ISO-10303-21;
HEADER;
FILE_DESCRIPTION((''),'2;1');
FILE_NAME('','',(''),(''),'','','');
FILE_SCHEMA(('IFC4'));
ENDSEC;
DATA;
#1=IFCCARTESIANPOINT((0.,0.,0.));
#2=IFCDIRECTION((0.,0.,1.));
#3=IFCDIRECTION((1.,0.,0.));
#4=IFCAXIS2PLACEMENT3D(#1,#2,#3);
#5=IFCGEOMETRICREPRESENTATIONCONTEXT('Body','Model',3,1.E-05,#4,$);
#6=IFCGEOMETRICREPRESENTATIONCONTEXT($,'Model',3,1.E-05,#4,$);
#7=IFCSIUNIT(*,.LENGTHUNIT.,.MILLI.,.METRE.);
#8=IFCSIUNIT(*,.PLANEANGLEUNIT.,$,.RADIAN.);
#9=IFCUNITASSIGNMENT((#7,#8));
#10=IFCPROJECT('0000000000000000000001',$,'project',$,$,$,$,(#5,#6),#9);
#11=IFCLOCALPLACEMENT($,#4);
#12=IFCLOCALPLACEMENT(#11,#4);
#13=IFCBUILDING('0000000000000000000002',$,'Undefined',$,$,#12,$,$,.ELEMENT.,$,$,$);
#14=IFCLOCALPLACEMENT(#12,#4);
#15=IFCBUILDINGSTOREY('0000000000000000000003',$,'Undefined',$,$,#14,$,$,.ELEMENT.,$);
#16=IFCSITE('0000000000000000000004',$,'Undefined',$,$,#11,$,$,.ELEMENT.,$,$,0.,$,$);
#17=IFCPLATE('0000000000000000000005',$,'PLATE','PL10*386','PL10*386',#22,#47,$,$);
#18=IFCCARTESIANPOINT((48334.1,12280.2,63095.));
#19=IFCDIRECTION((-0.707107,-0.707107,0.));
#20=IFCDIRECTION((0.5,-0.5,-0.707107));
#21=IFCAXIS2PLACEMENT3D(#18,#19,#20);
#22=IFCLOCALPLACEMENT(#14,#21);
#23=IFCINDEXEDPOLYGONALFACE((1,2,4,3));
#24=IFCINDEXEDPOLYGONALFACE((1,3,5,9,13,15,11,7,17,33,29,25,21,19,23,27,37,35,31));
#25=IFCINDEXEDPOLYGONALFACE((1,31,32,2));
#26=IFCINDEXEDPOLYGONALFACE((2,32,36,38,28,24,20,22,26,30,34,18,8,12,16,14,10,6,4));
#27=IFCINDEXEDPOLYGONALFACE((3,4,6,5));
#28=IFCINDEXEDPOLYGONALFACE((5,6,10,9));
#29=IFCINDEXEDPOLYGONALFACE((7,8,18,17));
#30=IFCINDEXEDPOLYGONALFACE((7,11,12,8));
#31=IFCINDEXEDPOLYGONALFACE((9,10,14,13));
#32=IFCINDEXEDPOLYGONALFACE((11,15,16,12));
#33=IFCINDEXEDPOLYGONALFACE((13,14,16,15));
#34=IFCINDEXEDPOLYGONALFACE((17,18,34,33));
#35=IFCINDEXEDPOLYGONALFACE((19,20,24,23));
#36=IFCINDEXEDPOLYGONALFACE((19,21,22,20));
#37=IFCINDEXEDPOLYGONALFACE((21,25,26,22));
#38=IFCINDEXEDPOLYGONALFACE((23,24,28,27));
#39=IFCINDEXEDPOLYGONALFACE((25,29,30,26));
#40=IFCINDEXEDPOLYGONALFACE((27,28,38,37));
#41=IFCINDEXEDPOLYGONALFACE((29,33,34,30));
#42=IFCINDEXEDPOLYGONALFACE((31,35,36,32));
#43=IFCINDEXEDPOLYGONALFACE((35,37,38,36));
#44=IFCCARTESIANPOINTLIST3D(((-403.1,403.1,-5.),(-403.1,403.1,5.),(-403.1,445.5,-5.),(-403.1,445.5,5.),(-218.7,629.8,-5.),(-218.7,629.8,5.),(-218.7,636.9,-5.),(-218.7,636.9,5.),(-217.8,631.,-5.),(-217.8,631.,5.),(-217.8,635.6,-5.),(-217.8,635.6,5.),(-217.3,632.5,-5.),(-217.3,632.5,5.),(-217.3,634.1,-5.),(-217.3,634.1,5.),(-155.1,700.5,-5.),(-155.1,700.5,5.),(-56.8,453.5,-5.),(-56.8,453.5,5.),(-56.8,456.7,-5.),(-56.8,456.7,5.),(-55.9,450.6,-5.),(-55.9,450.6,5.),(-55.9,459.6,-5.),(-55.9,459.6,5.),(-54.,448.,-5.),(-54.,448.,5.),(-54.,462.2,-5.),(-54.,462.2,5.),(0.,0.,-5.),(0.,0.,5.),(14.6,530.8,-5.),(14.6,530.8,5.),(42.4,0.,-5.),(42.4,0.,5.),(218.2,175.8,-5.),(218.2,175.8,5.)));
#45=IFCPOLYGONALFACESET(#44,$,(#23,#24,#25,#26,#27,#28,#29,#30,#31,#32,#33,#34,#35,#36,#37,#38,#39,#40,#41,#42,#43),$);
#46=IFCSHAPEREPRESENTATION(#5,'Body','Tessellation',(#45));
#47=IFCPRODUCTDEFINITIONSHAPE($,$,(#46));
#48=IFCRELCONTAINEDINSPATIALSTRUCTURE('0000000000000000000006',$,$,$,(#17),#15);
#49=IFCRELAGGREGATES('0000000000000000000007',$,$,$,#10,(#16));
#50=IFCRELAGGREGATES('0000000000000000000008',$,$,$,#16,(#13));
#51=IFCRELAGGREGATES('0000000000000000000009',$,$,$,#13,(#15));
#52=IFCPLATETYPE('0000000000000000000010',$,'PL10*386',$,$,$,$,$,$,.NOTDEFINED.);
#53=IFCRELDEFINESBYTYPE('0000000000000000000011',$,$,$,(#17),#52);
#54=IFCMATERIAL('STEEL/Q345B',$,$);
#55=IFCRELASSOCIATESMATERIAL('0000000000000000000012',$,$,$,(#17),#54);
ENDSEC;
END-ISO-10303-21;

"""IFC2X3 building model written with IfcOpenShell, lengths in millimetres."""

from ifc_helpers import new_model, si_unit, frame, origin_with_axes, place, context, project, spatial, polyline, outline, extrude, material, type_object, element, save


model = new_model("IFC2X3")

# Units and contexts
model_context_1 = context("Model", 3, precision=1e-05, world=origin_with_axes(), identifier="Body")
model_context_2 = context("Model", 3, precision=1e-05, world=origin_with_axes())
ifc_project = project(units=[si_unit("LENGTHUNIT", "METRE", prefix="MILLI"), si_unit("PLANEANGLEUNIT", "RADIAN")], contexts=[model_context_1, model_context_2])

# Site, building, storey
site_placement = place(None, origin_with_axes())
site = spatial("IfcSite", under=ifc_project, at=site_placement, Name="Undefined", CompositionType="ELEMENT", RefElevation=0.0)
building_placement = place(site_placement, origin_with_axes())
building = spatial("IfcBuilding", under=site, at=building_placement, Name="Undefined", CompositionType="ELEMENT")
storey_placement = place(building_placement, origin_with_axes())
storey = spatial("IfcBuildingStorey", under=building, at=storey_placement, Name="Undefined", CompositionType="ELEMENT")

# Shared definitions
ifc_material_1 = material(Name="STEEL/Q345B")

# Plate
plate_type_1 = type_object("IfcPlateType", Name="PL10*386", PredefinedType="NOTDEFINED")
plate_1_placement = place(storey_placement, frame((48334.1, 12280.2, 63095.0), z_axis=(-0.707107, -0.707107, 0.0), x_axis=(0.5, -0.5, -0.707107)))
element("IfcPlate", 1, at=plate_1_placement, inside=storey, type_object=plate_type_1, material=ifc_material_1, Name="PLATE", Description="PL10*386", ObjectType="PL10*386", context=model_context_1, shape_type="SweptSolid", body=[
    extrude(outline(polyline([(0.0, 0.0), (42.4, 0.0), (218.2, 175.8), (-54.0, 448.0), (-55.9, 450.6), (-56.8, 453.5), (-56.8, 456.7), (-55.9, 459.6), (-54.0, 462.2), (14.6, 530.8), (-155.1, 700.5), (-218.7, 636.9), (-217.8, 635.6), (-217.3, 634.1), (-217.3, 632.5), (-217.8, 631.0), (-218.7, 629.8), (-403.1, 445.5), (-403.1, 403.1), (0.0, 0.0)])), frame((0.0, 0.0, -5.0), z_axis=(0.0, 0.0, 1.0), x_axis=(1.0, 0.0, 0.0)), (0.0, 0.0, 1.0), 10.0),
])

save(model, "model.ifc")
